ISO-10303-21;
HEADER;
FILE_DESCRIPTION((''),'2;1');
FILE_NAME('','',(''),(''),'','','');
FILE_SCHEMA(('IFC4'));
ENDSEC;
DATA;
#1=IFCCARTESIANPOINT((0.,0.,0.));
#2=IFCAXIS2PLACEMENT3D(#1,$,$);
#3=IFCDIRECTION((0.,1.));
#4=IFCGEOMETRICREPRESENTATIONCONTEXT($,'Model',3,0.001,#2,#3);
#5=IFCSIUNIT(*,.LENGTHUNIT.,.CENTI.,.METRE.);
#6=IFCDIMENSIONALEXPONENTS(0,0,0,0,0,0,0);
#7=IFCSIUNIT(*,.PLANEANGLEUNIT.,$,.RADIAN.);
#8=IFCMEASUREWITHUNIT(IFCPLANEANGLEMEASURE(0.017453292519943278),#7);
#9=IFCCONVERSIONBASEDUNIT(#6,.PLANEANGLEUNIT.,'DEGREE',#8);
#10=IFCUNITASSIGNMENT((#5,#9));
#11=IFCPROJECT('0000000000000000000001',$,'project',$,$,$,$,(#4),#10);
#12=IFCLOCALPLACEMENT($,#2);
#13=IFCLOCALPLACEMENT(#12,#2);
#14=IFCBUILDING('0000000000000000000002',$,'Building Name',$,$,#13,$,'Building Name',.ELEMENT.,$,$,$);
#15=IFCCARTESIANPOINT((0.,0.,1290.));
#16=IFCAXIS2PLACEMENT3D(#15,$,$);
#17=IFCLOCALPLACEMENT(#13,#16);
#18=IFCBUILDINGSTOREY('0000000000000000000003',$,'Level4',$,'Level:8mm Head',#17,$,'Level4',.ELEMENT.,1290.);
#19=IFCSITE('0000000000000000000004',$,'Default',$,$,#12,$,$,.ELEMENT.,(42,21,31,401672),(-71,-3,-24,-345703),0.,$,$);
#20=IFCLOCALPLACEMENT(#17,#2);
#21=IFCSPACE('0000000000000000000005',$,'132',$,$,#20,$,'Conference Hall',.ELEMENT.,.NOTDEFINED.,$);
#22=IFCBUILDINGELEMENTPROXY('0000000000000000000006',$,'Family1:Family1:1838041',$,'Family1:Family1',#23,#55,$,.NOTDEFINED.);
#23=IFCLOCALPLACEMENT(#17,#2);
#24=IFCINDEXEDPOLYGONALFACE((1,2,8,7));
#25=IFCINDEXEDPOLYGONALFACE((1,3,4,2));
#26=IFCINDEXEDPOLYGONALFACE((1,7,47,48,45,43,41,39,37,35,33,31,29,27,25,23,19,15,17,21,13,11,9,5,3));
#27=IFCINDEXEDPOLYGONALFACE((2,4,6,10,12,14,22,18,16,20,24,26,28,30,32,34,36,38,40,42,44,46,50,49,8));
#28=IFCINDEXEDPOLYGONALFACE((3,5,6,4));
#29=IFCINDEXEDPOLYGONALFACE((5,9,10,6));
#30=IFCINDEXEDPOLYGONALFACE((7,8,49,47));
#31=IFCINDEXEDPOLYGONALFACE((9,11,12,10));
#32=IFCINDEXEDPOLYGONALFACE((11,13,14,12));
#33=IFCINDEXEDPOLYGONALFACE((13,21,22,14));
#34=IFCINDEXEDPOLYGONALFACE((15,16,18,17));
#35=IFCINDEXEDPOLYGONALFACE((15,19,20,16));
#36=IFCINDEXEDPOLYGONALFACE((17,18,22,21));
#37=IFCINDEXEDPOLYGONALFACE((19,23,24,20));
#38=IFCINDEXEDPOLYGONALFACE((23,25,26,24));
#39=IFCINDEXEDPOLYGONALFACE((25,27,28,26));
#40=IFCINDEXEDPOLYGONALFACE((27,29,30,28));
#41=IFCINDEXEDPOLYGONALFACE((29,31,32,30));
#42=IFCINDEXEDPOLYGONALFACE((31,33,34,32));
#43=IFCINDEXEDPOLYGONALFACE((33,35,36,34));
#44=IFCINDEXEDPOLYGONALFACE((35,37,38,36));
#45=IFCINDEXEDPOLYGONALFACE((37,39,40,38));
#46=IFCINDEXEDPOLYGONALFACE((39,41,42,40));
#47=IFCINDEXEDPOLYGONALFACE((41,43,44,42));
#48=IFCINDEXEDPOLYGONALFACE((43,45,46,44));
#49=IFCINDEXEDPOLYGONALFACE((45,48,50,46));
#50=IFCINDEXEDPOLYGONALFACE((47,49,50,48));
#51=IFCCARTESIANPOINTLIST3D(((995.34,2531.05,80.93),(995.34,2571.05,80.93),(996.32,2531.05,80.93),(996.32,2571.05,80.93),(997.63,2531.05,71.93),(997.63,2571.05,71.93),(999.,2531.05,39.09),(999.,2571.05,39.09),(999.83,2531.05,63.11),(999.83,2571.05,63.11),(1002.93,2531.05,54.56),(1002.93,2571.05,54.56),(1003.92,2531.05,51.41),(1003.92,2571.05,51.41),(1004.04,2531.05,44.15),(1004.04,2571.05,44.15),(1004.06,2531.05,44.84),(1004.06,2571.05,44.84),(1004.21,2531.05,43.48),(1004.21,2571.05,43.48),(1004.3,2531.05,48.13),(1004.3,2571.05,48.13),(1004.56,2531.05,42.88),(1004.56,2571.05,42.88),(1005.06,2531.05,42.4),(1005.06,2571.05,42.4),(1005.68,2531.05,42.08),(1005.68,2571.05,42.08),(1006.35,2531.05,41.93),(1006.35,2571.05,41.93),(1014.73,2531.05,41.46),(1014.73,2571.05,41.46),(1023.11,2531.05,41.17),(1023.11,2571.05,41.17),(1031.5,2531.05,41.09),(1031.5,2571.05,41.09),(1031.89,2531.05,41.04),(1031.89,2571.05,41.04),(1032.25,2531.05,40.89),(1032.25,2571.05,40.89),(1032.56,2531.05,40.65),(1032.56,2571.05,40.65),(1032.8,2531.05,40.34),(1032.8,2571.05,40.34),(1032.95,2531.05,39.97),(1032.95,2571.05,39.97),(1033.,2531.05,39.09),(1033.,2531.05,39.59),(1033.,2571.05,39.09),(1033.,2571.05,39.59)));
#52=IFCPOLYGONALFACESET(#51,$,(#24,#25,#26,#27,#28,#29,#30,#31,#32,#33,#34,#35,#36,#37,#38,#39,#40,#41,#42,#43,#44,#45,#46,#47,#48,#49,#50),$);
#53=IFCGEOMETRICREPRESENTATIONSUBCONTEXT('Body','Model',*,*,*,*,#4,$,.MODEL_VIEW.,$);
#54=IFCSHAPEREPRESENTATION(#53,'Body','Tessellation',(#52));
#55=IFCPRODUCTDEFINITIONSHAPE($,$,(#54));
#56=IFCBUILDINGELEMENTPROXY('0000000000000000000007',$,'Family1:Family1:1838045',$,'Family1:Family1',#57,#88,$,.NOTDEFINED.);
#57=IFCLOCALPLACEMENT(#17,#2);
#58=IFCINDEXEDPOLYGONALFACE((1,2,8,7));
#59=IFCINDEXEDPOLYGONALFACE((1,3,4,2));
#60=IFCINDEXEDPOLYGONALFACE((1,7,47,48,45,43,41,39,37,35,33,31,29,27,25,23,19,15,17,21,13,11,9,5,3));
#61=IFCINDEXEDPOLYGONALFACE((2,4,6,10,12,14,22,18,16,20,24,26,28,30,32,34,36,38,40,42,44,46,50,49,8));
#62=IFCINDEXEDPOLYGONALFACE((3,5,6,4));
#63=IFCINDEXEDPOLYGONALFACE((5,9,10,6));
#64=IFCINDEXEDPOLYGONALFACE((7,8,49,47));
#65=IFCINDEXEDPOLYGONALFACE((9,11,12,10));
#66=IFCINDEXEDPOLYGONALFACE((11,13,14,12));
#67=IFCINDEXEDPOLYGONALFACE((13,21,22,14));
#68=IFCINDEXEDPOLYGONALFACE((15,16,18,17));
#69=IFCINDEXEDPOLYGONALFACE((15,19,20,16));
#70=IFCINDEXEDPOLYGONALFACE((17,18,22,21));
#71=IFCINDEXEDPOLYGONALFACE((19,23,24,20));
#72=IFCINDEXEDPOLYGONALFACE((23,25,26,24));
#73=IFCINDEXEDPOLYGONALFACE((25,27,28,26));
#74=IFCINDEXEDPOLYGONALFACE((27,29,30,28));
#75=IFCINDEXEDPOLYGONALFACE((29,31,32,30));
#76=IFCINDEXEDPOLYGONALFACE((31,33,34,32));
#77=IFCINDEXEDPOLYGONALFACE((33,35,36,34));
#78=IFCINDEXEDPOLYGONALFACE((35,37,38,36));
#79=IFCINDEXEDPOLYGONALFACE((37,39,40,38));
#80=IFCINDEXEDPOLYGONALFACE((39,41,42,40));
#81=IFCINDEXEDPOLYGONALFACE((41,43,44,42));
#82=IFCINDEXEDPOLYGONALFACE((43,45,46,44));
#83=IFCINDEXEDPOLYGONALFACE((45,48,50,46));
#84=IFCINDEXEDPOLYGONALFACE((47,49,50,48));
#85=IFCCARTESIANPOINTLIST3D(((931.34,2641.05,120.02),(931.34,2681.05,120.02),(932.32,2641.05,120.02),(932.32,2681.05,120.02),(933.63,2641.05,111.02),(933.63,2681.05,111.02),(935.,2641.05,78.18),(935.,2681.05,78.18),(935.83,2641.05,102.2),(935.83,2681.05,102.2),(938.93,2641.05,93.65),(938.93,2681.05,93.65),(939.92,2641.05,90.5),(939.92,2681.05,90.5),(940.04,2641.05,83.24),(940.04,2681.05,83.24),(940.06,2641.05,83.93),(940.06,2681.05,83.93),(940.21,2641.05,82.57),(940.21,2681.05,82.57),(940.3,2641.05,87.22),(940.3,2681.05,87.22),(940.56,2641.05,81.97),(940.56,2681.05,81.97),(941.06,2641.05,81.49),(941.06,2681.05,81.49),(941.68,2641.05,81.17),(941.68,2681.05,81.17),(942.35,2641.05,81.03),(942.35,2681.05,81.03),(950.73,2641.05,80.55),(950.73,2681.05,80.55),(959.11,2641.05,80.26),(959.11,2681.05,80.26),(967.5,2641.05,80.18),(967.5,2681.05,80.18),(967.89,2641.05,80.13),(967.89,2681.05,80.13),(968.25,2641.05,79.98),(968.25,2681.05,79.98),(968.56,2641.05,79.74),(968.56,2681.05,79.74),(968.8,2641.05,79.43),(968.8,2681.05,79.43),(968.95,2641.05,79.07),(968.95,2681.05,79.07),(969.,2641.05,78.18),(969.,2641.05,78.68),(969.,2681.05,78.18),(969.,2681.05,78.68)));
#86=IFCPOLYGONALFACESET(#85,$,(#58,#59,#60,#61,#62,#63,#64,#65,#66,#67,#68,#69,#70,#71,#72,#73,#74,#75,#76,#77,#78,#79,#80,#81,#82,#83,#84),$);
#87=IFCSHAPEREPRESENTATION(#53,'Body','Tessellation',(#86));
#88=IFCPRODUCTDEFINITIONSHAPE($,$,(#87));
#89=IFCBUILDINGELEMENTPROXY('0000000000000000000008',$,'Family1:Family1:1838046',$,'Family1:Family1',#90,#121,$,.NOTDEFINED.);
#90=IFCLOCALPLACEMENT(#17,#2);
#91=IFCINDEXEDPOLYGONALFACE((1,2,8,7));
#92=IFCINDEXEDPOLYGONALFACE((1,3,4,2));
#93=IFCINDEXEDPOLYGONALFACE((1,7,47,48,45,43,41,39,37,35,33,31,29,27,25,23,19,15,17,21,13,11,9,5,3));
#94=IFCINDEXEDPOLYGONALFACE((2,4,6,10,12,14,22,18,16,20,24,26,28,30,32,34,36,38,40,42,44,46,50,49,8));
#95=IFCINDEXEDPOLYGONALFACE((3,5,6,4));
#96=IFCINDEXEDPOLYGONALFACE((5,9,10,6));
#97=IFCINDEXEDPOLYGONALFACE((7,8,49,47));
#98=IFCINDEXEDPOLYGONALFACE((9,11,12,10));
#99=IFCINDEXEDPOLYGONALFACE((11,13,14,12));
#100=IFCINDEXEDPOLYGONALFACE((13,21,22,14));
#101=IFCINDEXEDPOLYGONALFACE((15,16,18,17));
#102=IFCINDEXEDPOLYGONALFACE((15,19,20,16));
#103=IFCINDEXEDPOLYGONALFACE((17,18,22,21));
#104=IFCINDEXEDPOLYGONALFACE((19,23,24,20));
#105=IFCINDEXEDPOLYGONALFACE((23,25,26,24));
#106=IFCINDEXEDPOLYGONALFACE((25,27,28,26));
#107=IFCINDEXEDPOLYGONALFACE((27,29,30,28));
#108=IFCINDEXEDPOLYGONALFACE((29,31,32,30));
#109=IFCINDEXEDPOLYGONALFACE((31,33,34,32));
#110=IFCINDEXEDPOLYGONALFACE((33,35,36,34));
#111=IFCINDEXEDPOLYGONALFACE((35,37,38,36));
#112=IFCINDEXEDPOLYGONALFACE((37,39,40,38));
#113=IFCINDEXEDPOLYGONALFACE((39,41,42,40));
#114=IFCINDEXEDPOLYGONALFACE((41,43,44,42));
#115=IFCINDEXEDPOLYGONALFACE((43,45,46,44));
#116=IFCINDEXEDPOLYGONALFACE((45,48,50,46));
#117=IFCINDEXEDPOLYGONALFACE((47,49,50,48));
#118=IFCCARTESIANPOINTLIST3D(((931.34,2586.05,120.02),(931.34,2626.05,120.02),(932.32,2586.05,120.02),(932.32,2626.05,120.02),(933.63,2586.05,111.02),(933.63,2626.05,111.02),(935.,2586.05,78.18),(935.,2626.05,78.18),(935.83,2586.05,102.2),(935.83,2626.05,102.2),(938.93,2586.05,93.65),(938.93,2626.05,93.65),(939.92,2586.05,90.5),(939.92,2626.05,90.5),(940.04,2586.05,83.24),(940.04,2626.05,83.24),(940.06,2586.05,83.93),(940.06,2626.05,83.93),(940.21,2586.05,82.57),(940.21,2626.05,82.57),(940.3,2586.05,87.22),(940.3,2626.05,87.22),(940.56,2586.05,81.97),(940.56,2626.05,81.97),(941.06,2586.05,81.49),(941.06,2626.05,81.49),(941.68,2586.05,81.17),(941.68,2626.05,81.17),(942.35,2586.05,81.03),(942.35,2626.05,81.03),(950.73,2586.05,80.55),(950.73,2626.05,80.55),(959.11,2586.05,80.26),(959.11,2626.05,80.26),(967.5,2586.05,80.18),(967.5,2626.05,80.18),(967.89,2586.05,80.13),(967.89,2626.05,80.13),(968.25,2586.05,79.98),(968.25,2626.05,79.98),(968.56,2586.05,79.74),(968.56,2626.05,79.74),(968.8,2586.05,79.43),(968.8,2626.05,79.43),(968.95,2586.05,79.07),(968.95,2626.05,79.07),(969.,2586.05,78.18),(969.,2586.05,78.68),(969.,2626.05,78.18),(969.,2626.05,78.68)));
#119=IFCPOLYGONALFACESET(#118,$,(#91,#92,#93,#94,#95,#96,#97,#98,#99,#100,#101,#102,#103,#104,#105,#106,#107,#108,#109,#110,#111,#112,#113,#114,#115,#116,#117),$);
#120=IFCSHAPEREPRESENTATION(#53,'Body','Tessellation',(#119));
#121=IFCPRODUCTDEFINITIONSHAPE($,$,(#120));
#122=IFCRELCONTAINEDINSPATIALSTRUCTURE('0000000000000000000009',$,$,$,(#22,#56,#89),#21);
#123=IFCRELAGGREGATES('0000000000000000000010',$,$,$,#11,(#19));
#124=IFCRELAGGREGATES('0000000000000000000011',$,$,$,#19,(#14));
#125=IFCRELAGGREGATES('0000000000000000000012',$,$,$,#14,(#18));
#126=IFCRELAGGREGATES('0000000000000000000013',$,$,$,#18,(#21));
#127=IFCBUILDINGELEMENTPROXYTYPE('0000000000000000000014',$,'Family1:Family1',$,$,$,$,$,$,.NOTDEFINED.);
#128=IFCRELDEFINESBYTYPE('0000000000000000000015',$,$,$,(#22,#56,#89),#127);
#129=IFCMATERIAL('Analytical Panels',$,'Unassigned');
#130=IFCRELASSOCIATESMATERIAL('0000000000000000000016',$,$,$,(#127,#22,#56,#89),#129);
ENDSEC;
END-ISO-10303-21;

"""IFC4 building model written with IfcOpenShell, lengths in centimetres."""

from ifc_helpers import new_model, entity, si_unit, converted_unit, direction, frame, origin, place, context, subcontext, project, spatial, line, arc, indexed_curve, outline, extrude, source, transform, mapped, material, type_object, type_shapes, element, save


model = new_model("IFC4")

# Units and contexts
model_context = context("Model", 3, precision=0.001, world=origin(), true_north=direction((0.0, 1.0)))
body_context = subcontext(model_context, "Body", "Model", "MODEL_VIEW")
ifc_project = project(units=[si_unit("LENGTHUNIT", "METRE", prefix="CENTI"), converted_unit("PLANEANGLEUNIT", "DEGREE", entity("IfcPlaneAngleMeasure", 0.017453292519943278), si_unit("PLANEANGLEUNIT", "RADIAN"), dimensions=[0, 0, 0, 0, 0, 0, 0])], contexts=[model_context])

# Site, building, storey
site_placement = place(None, origin())
site = spatial("IfcSite", under=ifc_project, at=site_placement, Name="Default", CompositionType="ELEMENT", RefLatitude=(42, 21, 31, 401672), RefLongitude=(-71, -3, -24, -345703), RefElevation=0.0)
building_placement = place(site_placement, origin())
building = spatial("IfcBuilding", under=site, at=building_placement, Name="Building Name", LongName="Building Name", CompositionType="ELEMENT")
storey_placement = place(building_placement, frame((0.0, 0.0, 1290.0)))
storey = spatial("IfcBuildingStorey", under=building, at=storey_placement, Name="Level4", ObjectType="Level:8mm Head", LongName="Level4", CompositionType="ELEMENT", Elevation=1290.0)

# Shared definitions
space_placement = place(storey_placement, origin())
space = spatial("IfcSpace", under=storey, at=space_placement, Name="132", LongName="Conference Hall", CompositionType="ELEMENT", PredefinedType="NOTDEFINED")

# Building element proxies
ifc_material_1 = material(Name="Analytical Panels", Category="Unassigned")
building_element_proxy_type_1 = type_object("IfcBuildingElementProxyType", Name="Family1:Family1", PredefinedType="NOTDEFINED", material=ifc_material_1)
shared_shape_1 = source(origin(), body_context, "Body", "SweptSolid", [
    extrude(outline(indexed_curve([(-11.13, -13.3), (30.87, -13.3), (30.78, -12.32), (17.19, -11.21), (3.93, -8.04), (-0.94, -7.2), (-5.84, -7.76), (-7.84, -7.43), (-8.94, -5.73), (-10.68, 6.74), (-11.98, 19.25), (-12.51, 20.27), (-13.6, 20.61), (-14.09, 20.57)], segments=[line(1, 2, 3), arc(3, 4, 5), arc(5, 6, 7), arc(7, 8, 9), arc(9, 10, 11), arc(11, 12, 13), line(13, 14, 1)], self_intersect=False)), frame((-20.0, 6.72, 12.25), z_axis=(1.0, 0.0, 0.0), x_axis=(0.0, 0.087156, 0.996195)), (0.0, 0.0, 1.0), 40.0),
])
type_shapes(building_element_proxy_type_1, [shared_shape_1])
for number, where, z_axis, x_axis, name in (
    (1, (1018.0, 2551.05, 39.09), (0.0, 0.0, 1.0), (0.0, 1.0, 0.0), "Family1:Family1:1838041"),
    (2, (954.0, 2661.05, 78.18), (0.0, 0.0, 1.0), (0.0, 1.0, 0.0), "Family1:Family1:1838045"),
    (3, (954.0, 2606.05, 78.18), (0.0, 0.0, 1.0), (0.0, 1.0, 0.0), "Family1:Family1:1838046"),
):
    element("IfcBuildingElementProxy", number, at=place(space_placement, frame(where, z_axis=z_axis, x_axis=x_axis)), inside=space, type_object=building_element_proxy_type_1, material=ifc_material_1, Name=name, ObjectType="Family1:Family1", PredefinedType="NOTDEFINED", context=body_context, shape_type="MappedRepresentation", body=[
        mapped(shared_shape_1, transform((0.0, 0.0, 0.0), scale=1.0)),
    ])

save(model, "model.ifc")
